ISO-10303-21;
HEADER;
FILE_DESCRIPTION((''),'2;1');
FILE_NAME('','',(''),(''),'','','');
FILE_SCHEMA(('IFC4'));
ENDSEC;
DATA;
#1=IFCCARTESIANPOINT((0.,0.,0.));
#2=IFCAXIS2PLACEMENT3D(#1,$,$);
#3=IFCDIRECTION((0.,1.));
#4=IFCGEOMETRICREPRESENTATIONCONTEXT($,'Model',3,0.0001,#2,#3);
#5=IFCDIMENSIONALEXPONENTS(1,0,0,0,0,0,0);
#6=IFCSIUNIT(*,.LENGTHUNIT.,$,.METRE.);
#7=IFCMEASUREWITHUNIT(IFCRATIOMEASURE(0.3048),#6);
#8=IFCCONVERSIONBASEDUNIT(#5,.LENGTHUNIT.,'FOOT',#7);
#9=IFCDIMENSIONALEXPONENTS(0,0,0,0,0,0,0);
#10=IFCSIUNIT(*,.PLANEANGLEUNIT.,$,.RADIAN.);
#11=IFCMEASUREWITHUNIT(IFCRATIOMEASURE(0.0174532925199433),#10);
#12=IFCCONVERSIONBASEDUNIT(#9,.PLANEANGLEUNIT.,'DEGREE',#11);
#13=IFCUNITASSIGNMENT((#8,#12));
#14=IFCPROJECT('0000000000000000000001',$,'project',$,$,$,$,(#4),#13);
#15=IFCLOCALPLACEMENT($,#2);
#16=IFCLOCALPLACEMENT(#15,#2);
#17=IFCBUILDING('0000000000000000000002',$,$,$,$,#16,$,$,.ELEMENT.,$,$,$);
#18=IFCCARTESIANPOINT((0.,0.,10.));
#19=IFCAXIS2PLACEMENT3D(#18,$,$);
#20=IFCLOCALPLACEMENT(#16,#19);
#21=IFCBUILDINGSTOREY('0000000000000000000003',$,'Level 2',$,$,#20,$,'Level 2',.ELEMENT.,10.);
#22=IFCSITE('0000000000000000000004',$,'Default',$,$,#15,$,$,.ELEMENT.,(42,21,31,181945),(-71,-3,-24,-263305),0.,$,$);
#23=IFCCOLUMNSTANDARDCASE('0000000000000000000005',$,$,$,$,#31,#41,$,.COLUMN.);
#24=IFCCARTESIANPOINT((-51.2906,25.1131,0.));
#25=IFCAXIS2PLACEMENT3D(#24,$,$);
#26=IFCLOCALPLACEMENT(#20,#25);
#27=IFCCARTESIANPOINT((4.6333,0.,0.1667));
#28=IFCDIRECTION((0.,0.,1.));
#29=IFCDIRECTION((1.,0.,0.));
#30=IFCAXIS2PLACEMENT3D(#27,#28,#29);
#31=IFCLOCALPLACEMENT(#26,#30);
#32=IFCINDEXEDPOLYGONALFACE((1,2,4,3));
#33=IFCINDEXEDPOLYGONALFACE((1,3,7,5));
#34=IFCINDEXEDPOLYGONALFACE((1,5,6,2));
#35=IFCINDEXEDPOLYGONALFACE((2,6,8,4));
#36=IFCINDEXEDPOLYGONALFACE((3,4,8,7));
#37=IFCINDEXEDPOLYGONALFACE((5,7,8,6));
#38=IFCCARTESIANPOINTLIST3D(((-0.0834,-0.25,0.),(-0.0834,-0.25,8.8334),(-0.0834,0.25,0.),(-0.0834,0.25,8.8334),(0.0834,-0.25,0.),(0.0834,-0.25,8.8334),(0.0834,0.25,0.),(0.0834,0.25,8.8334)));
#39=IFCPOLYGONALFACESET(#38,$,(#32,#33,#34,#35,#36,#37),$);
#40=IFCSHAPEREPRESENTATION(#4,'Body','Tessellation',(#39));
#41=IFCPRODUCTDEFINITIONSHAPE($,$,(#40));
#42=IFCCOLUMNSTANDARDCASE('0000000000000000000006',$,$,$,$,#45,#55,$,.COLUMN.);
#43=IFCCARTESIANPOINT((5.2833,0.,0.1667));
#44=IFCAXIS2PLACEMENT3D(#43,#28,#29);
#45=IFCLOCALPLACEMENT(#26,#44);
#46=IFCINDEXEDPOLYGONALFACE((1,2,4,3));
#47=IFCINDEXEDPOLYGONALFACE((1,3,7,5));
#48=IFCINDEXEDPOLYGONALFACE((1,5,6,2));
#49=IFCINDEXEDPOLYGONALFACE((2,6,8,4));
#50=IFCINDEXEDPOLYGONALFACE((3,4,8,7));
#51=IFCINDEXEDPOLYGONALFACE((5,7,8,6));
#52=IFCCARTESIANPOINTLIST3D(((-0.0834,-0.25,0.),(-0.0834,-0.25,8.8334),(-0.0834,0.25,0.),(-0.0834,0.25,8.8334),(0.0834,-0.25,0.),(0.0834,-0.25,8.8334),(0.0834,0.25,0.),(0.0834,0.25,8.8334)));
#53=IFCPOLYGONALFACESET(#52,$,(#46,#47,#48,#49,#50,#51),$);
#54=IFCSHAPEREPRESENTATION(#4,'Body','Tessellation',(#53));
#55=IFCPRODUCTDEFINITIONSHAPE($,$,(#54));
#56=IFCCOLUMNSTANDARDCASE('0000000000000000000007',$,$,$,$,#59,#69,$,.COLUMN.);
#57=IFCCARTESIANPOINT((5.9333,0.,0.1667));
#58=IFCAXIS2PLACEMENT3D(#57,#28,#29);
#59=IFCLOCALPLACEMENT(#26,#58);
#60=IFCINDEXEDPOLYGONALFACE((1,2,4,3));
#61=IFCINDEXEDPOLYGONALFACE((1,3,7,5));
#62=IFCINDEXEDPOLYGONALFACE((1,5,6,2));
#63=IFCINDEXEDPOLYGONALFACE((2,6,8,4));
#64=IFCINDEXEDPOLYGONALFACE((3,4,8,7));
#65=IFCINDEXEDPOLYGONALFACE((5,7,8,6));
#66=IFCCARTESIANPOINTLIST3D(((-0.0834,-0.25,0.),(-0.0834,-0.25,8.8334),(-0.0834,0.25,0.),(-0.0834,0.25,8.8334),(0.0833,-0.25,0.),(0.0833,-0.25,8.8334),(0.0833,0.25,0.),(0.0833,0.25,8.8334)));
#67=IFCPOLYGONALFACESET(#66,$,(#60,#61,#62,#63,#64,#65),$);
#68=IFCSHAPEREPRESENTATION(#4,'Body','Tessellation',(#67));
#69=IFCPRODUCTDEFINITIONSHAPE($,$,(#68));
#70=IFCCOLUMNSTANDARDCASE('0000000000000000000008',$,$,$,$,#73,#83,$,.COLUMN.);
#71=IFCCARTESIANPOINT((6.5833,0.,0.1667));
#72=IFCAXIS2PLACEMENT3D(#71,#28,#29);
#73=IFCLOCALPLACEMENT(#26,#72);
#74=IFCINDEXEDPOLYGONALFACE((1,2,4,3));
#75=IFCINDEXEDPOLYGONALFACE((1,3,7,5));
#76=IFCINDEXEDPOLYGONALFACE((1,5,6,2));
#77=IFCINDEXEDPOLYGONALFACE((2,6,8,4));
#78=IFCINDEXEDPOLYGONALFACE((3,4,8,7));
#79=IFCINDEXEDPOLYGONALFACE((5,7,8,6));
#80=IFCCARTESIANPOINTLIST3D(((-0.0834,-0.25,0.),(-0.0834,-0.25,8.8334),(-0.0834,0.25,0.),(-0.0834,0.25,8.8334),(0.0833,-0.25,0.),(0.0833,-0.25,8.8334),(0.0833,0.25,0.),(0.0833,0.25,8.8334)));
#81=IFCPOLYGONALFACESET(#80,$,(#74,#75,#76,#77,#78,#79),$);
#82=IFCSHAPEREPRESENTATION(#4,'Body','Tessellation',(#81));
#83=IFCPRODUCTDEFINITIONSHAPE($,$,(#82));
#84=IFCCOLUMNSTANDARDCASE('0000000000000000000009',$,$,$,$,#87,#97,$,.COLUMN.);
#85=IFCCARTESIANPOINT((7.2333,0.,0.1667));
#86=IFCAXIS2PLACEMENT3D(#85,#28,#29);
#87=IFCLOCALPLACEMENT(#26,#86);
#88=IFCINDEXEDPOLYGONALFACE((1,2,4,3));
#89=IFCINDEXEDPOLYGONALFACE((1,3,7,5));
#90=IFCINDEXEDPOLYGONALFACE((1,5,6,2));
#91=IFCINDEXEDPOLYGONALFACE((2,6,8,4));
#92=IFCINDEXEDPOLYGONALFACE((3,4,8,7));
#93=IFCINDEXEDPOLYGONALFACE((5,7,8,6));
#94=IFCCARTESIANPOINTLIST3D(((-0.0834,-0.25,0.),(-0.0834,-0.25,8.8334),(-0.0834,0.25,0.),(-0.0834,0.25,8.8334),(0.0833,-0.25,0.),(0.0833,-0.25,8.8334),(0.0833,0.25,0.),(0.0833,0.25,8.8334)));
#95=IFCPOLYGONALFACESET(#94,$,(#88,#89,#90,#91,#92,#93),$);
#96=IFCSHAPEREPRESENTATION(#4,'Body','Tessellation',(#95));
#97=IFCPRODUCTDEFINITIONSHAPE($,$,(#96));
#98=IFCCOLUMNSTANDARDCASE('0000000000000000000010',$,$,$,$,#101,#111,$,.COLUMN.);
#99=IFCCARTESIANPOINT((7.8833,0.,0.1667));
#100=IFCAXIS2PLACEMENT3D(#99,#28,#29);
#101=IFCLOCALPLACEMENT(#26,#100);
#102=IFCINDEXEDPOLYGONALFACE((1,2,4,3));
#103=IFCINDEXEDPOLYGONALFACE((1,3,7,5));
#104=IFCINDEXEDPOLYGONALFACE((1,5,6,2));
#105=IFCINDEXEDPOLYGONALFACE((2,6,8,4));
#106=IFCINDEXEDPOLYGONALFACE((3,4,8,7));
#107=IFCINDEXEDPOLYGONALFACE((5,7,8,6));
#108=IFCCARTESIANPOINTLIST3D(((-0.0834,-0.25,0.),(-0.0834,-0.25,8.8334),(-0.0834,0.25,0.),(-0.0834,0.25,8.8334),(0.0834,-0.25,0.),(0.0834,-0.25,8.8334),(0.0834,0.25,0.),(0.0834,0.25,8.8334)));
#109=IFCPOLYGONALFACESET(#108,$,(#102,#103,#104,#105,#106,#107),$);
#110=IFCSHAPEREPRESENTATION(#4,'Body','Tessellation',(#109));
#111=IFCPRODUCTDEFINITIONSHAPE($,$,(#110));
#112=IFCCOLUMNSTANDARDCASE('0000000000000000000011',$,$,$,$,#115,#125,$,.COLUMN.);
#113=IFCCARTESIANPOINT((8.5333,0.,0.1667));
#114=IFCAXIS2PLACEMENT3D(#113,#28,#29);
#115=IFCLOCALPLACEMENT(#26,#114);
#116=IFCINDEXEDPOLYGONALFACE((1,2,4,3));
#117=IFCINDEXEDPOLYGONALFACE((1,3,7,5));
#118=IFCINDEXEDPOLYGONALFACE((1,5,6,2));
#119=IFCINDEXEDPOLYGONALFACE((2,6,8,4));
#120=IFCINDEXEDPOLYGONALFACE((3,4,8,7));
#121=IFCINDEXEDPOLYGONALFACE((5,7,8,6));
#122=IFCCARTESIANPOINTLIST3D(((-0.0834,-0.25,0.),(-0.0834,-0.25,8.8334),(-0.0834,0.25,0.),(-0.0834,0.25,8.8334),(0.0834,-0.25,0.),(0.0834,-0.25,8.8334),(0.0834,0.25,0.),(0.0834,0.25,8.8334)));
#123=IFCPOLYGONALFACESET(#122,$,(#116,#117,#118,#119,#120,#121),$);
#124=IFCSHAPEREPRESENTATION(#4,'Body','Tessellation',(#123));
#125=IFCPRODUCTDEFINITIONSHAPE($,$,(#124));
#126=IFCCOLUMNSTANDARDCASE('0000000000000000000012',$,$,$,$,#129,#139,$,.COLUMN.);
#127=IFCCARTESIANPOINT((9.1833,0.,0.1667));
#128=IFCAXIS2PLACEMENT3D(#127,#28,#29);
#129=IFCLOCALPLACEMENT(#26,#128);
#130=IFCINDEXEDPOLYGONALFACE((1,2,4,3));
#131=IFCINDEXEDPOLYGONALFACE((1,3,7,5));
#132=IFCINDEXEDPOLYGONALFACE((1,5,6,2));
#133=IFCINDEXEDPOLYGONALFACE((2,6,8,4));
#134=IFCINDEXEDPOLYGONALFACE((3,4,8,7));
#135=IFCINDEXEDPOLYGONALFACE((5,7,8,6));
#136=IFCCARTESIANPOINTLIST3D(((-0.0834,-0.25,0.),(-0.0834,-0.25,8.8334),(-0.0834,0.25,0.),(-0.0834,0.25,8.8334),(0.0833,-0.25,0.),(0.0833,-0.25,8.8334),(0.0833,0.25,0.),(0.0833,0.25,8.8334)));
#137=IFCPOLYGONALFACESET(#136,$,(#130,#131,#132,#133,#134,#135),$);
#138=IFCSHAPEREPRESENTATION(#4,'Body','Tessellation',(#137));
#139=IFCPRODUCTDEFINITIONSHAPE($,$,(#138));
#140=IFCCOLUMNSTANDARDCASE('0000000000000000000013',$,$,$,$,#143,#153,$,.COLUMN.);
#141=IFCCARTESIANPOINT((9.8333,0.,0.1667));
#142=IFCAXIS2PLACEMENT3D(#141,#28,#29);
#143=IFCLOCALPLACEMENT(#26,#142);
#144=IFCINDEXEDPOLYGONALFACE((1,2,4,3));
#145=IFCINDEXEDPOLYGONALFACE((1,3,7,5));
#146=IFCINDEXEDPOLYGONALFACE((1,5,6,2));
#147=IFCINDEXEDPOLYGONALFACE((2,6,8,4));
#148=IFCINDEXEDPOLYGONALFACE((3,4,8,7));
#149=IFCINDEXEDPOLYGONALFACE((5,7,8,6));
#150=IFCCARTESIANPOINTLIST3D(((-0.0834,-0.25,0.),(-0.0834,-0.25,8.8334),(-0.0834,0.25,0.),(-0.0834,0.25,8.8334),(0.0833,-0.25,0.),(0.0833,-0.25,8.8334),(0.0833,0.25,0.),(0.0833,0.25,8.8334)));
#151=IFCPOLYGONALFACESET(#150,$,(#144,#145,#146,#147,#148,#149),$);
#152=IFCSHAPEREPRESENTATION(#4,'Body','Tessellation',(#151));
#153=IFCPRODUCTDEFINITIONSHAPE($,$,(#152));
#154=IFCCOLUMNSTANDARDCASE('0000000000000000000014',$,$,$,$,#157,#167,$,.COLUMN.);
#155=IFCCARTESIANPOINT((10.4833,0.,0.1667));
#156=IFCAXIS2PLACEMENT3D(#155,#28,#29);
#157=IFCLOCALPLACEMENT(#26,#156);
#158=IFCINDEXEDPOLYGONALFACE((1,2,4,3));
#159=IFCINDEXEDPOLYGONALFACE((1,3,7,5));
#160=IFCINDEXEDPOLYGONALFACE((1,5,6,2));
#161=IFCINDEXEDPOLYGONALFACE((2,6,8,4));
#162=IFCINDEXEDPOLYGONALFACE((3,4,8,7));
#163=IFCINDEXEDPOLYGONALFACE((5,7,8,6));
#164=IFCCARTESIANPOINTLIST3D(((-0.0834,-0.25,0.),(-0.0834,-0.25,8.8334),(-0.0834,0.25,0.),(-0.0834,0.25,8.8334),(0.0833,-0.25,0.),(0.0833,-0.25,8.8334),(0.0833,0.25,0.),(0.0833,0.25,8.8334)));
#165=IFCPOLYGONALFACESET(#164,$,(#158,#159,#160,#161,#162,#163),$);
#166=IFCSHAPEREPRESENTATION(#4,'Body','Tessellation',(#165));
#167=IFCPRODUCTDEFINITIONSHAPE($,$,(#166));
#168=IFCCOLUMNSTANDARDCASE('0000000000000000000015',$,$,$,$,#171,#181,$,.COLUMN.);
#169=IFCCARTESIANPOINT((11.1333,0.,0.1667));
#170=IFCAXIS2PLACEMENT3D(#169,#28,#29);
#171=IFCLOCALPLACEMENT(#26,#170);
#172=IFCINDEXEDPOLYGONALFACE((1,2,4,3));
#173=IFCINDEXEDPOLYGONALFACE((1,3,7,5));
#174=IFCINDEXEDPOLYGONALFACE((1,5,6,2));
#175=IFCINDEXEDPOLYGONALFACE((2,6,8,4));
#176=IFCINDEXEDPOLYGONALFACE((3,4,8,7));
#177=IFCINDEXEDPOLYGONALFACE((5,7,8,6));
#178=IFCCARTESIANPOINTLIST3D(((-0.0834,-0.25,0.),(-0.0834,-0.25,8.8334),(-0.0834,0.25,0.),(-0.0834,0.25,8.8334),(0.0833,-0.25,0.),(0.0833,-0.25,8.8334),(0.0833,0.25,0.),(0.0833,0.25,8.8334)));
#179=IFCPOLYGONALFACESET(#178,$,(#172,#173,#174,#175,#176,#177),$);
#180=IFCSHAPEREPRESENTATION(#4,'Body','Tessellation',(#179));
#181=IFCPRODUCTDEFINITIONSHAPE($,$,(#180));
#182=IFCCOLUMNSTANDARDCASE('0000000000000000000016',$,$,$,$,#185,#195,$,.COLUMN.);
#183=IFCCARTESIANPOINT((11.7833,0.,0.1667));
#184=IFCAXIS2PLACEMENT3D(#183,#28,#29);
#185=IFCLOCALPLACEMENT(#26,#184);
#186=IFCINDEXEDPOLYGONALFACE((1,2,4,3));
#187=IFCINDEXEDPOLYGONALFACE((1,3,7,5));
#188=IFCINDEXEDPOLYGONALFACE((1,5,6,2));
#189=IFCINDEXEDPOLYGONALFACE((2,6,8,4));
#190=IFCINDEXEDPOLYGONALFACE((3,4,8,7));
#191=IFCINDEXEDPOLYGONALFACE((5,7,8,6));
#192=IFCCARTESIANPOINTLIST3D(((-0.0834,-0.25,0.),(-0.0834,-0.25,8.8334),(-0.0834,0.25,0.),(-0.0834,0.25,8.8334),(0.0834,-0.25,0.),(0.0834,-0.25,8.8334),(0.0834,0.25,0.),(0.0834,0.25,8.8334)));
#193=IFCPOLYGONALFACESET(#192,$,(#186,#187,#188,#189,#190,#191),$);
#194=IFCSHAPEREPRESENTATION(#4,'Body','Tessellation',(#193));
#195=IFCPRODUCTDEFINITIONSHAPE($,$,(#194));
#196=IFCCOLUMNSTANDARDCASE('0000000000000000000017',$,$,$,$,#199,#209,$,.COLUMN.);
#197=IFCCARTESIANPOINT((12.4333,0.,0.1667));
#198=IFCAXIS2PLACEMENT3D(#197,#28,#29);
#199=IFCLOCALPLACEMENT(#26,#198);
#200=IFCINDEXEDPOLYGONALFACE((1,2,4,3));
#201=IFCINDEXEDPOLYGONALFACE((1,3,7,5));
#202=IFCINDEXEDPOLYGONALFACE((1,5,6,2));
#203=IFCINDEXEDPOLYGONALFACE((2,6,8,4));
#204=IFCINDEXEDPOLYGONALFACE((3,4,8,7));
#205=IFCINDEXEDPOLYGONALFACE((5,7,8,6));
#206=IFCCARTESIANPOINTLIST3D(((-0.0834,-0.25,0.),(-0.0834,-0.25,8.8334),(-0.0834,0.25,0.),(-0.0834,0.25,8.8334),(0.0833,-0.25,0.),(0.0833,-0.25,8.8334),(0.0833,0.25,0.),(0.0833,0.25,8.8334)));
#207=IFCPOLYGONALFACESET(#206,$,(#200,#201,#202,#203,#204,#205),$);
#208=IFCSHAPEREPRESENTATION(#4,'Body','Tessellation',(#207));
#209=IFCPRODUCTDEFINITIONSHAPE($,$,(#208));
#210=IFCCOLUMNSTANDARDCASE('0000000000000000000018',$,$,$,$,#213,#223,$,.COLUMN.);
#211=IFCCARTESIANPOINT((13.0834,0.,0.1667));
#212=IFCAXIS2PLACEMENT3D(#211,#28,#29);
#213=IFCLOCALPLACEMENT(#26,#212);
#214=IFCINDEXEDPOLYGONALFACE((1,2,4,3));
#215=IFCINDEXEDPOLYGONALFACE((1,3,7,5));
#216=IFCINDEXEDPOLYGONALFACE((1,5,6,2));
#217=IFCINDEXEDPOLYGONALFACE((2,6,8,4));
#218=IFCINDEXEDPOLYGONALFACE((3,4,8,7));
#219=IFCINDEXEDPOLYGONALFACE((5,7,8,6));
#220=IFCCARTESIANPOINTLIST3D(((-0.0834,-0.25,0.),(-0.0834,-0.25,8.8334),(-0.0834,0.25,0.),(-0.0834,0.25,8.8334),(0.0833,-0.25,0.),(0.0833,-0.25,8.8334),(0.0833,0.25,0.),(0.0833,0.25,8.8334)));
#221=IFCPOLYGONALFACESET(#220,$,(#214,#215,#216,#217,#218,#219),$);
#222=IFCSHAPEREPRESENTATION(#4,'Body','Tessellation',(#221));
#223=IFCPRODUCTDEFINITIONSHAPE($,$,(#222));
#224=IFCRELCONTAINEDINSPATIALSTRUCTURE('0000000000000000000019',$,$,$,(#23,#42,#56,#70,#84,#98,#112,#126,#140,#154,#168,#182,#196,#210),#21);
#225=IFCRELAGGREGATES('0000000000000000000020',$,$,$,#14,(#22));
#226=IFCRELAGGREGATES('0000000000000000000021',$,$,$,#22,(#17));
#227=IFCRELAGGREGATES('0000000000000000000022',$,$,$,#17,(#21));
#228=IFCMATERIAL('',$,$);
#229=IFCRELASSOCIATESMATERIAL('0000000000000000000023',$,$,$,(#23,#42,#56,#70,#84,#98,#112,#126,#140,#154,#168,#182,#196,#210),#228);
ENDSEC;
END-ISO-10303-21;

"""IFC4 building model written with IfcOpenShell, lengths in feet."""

from ifc_helpers import new_model, entity, si_unit, converted_unit, direction, frame, origin, place, context, project, spatial, rectangle, extrude, material, element, save


model = new_model("IFC4")

# Units and contexts
model_context = context("Model", 3, precision=0.0001, world=origin(), true_north=direction((0.0, 1.0)))
ifc_project = project(units=[converted_unit("LENGTHUNIT", "FOOT", entity("IfcRatioMeasure", 0.3048), si_unit("LENGTHUNIT", "METRE"), dimensions=[1, 0, 0, 0, 0, 0, 0]), converted_unit("PLANEANGLEUNIT", "DEGREE", entity("IfcRatioMeasure", 0.0174532925199433), si_unit("PLANEANGLEUNIT", "RADIAN"), dimensions=[0, 0, 0, 0, 0, 0, 0])], contexts=[model_context])

# Site, building, storey
site_placement = place(None, origin())
site = spatial("IfcSite", under=ifc_project, at=site_placement, Name="Default", CompositionType="ELEMENT", RefLatitude=(42, 21, 31, 181945), RefLongitude=(-71, -3, -24, -263305), RefElevation=0.0)
building_placement = place(site_placement, origin())
building = spatial("IfcBuilding", under=site, at=building_placement, CompositionType="ELEMENT")
storey_placement = place(building_placement, frame((0.0, 0.0, 10.0)))
storey = spatial("IfcBuildingStorey", under=building, at=storey_placement, Name="Level 2", LongName="Level 2", CompositionType="ELEMENT", Elevation=10.0)

# Columns
ifc_material_1 = material(Name="")
placement_1 = place(storey_placement, frame((-51.2906, 25.1131, 0.0)))
for number, where, z_axis, x_axis in (
    (1, (4.6333, 0.0, 0.1667), (0.0, 0.0, 1.0), (1.0, 0.0, 0.0)),
    (2, (5.2833, 0.0, 0.1667), (0.0, 0.0, 1.0), (1.0, 0.0, 0.0)),
    (3, (5.9333, 0.0, 0.1667), (0.0, 0.0, 1.0), (1.0, 0.0, 0.0)),
    (4, (6.5833, 0.0, 0.1667), (0.0, 0.0, 1.0), (1.0, 0.0, 0.0)),
    (5, (7.2333, 0.0, 0.1667), (0.0, 0.0, 1.0), (1.0, 0.0, 0.0)),
    (6, (7.8833, 0.0, 0.1667), (0.0, 0.0, 1.0), (1.0, 0.0, 0.0)),
    (7, (8.5333, 0.0, 0.1667), (0.0, 0.0, 1.0), (1.0, 0.0, 0.0)),
    (8, (9.1833, 0.0, 0.1667), (0.0, 0.0, 1.0), (1.0, 0.0, 0.0)),
    (9, (9.8333, 0.0, 0.1667), (0.0, 0.0, 1.0), (1.0, 0.0, 0.0)),
    (10, (10.4833, 0.0, 0.1667), (0.0, 0.0, 1.0), (1.0, 0.0, 0.0)),
    (11, (11.1333, 0.0, 0.1667), (0.0, 0.0, 1.0), (1.0, 0.0, 0.0)),
    (12, (11.7833, 0.0, 0.1667), (0.0, 0.0, 1.0), (1.0, 0.0, 0.0)),
    (13, (12.4333, 0.0, 0.1667), (0.0, 0.0, 1.0), (1.0, 0.0, 0.0)),
    (14, (13.0834, 0.0, 0.1667), (0.0, 0.0, 1.0), (1.0, 0.0, 0.0)),
):
    element("IfcColumnStandardCase", number, at=place(placement_1, frame(where, z_axis=z_axis, x_axis=x_axis)), inside=storey, material=ifc_material_1, PredefinedType="COLUMN", context=model_context, shape_type="SweptSolid", body=[
        extrude(rectangle(XDim=0.1667, YDim=0.5), origin(), (0.0, 0.0, 1.0), 8.8334),
    ])

save(model, "model.ifc")
